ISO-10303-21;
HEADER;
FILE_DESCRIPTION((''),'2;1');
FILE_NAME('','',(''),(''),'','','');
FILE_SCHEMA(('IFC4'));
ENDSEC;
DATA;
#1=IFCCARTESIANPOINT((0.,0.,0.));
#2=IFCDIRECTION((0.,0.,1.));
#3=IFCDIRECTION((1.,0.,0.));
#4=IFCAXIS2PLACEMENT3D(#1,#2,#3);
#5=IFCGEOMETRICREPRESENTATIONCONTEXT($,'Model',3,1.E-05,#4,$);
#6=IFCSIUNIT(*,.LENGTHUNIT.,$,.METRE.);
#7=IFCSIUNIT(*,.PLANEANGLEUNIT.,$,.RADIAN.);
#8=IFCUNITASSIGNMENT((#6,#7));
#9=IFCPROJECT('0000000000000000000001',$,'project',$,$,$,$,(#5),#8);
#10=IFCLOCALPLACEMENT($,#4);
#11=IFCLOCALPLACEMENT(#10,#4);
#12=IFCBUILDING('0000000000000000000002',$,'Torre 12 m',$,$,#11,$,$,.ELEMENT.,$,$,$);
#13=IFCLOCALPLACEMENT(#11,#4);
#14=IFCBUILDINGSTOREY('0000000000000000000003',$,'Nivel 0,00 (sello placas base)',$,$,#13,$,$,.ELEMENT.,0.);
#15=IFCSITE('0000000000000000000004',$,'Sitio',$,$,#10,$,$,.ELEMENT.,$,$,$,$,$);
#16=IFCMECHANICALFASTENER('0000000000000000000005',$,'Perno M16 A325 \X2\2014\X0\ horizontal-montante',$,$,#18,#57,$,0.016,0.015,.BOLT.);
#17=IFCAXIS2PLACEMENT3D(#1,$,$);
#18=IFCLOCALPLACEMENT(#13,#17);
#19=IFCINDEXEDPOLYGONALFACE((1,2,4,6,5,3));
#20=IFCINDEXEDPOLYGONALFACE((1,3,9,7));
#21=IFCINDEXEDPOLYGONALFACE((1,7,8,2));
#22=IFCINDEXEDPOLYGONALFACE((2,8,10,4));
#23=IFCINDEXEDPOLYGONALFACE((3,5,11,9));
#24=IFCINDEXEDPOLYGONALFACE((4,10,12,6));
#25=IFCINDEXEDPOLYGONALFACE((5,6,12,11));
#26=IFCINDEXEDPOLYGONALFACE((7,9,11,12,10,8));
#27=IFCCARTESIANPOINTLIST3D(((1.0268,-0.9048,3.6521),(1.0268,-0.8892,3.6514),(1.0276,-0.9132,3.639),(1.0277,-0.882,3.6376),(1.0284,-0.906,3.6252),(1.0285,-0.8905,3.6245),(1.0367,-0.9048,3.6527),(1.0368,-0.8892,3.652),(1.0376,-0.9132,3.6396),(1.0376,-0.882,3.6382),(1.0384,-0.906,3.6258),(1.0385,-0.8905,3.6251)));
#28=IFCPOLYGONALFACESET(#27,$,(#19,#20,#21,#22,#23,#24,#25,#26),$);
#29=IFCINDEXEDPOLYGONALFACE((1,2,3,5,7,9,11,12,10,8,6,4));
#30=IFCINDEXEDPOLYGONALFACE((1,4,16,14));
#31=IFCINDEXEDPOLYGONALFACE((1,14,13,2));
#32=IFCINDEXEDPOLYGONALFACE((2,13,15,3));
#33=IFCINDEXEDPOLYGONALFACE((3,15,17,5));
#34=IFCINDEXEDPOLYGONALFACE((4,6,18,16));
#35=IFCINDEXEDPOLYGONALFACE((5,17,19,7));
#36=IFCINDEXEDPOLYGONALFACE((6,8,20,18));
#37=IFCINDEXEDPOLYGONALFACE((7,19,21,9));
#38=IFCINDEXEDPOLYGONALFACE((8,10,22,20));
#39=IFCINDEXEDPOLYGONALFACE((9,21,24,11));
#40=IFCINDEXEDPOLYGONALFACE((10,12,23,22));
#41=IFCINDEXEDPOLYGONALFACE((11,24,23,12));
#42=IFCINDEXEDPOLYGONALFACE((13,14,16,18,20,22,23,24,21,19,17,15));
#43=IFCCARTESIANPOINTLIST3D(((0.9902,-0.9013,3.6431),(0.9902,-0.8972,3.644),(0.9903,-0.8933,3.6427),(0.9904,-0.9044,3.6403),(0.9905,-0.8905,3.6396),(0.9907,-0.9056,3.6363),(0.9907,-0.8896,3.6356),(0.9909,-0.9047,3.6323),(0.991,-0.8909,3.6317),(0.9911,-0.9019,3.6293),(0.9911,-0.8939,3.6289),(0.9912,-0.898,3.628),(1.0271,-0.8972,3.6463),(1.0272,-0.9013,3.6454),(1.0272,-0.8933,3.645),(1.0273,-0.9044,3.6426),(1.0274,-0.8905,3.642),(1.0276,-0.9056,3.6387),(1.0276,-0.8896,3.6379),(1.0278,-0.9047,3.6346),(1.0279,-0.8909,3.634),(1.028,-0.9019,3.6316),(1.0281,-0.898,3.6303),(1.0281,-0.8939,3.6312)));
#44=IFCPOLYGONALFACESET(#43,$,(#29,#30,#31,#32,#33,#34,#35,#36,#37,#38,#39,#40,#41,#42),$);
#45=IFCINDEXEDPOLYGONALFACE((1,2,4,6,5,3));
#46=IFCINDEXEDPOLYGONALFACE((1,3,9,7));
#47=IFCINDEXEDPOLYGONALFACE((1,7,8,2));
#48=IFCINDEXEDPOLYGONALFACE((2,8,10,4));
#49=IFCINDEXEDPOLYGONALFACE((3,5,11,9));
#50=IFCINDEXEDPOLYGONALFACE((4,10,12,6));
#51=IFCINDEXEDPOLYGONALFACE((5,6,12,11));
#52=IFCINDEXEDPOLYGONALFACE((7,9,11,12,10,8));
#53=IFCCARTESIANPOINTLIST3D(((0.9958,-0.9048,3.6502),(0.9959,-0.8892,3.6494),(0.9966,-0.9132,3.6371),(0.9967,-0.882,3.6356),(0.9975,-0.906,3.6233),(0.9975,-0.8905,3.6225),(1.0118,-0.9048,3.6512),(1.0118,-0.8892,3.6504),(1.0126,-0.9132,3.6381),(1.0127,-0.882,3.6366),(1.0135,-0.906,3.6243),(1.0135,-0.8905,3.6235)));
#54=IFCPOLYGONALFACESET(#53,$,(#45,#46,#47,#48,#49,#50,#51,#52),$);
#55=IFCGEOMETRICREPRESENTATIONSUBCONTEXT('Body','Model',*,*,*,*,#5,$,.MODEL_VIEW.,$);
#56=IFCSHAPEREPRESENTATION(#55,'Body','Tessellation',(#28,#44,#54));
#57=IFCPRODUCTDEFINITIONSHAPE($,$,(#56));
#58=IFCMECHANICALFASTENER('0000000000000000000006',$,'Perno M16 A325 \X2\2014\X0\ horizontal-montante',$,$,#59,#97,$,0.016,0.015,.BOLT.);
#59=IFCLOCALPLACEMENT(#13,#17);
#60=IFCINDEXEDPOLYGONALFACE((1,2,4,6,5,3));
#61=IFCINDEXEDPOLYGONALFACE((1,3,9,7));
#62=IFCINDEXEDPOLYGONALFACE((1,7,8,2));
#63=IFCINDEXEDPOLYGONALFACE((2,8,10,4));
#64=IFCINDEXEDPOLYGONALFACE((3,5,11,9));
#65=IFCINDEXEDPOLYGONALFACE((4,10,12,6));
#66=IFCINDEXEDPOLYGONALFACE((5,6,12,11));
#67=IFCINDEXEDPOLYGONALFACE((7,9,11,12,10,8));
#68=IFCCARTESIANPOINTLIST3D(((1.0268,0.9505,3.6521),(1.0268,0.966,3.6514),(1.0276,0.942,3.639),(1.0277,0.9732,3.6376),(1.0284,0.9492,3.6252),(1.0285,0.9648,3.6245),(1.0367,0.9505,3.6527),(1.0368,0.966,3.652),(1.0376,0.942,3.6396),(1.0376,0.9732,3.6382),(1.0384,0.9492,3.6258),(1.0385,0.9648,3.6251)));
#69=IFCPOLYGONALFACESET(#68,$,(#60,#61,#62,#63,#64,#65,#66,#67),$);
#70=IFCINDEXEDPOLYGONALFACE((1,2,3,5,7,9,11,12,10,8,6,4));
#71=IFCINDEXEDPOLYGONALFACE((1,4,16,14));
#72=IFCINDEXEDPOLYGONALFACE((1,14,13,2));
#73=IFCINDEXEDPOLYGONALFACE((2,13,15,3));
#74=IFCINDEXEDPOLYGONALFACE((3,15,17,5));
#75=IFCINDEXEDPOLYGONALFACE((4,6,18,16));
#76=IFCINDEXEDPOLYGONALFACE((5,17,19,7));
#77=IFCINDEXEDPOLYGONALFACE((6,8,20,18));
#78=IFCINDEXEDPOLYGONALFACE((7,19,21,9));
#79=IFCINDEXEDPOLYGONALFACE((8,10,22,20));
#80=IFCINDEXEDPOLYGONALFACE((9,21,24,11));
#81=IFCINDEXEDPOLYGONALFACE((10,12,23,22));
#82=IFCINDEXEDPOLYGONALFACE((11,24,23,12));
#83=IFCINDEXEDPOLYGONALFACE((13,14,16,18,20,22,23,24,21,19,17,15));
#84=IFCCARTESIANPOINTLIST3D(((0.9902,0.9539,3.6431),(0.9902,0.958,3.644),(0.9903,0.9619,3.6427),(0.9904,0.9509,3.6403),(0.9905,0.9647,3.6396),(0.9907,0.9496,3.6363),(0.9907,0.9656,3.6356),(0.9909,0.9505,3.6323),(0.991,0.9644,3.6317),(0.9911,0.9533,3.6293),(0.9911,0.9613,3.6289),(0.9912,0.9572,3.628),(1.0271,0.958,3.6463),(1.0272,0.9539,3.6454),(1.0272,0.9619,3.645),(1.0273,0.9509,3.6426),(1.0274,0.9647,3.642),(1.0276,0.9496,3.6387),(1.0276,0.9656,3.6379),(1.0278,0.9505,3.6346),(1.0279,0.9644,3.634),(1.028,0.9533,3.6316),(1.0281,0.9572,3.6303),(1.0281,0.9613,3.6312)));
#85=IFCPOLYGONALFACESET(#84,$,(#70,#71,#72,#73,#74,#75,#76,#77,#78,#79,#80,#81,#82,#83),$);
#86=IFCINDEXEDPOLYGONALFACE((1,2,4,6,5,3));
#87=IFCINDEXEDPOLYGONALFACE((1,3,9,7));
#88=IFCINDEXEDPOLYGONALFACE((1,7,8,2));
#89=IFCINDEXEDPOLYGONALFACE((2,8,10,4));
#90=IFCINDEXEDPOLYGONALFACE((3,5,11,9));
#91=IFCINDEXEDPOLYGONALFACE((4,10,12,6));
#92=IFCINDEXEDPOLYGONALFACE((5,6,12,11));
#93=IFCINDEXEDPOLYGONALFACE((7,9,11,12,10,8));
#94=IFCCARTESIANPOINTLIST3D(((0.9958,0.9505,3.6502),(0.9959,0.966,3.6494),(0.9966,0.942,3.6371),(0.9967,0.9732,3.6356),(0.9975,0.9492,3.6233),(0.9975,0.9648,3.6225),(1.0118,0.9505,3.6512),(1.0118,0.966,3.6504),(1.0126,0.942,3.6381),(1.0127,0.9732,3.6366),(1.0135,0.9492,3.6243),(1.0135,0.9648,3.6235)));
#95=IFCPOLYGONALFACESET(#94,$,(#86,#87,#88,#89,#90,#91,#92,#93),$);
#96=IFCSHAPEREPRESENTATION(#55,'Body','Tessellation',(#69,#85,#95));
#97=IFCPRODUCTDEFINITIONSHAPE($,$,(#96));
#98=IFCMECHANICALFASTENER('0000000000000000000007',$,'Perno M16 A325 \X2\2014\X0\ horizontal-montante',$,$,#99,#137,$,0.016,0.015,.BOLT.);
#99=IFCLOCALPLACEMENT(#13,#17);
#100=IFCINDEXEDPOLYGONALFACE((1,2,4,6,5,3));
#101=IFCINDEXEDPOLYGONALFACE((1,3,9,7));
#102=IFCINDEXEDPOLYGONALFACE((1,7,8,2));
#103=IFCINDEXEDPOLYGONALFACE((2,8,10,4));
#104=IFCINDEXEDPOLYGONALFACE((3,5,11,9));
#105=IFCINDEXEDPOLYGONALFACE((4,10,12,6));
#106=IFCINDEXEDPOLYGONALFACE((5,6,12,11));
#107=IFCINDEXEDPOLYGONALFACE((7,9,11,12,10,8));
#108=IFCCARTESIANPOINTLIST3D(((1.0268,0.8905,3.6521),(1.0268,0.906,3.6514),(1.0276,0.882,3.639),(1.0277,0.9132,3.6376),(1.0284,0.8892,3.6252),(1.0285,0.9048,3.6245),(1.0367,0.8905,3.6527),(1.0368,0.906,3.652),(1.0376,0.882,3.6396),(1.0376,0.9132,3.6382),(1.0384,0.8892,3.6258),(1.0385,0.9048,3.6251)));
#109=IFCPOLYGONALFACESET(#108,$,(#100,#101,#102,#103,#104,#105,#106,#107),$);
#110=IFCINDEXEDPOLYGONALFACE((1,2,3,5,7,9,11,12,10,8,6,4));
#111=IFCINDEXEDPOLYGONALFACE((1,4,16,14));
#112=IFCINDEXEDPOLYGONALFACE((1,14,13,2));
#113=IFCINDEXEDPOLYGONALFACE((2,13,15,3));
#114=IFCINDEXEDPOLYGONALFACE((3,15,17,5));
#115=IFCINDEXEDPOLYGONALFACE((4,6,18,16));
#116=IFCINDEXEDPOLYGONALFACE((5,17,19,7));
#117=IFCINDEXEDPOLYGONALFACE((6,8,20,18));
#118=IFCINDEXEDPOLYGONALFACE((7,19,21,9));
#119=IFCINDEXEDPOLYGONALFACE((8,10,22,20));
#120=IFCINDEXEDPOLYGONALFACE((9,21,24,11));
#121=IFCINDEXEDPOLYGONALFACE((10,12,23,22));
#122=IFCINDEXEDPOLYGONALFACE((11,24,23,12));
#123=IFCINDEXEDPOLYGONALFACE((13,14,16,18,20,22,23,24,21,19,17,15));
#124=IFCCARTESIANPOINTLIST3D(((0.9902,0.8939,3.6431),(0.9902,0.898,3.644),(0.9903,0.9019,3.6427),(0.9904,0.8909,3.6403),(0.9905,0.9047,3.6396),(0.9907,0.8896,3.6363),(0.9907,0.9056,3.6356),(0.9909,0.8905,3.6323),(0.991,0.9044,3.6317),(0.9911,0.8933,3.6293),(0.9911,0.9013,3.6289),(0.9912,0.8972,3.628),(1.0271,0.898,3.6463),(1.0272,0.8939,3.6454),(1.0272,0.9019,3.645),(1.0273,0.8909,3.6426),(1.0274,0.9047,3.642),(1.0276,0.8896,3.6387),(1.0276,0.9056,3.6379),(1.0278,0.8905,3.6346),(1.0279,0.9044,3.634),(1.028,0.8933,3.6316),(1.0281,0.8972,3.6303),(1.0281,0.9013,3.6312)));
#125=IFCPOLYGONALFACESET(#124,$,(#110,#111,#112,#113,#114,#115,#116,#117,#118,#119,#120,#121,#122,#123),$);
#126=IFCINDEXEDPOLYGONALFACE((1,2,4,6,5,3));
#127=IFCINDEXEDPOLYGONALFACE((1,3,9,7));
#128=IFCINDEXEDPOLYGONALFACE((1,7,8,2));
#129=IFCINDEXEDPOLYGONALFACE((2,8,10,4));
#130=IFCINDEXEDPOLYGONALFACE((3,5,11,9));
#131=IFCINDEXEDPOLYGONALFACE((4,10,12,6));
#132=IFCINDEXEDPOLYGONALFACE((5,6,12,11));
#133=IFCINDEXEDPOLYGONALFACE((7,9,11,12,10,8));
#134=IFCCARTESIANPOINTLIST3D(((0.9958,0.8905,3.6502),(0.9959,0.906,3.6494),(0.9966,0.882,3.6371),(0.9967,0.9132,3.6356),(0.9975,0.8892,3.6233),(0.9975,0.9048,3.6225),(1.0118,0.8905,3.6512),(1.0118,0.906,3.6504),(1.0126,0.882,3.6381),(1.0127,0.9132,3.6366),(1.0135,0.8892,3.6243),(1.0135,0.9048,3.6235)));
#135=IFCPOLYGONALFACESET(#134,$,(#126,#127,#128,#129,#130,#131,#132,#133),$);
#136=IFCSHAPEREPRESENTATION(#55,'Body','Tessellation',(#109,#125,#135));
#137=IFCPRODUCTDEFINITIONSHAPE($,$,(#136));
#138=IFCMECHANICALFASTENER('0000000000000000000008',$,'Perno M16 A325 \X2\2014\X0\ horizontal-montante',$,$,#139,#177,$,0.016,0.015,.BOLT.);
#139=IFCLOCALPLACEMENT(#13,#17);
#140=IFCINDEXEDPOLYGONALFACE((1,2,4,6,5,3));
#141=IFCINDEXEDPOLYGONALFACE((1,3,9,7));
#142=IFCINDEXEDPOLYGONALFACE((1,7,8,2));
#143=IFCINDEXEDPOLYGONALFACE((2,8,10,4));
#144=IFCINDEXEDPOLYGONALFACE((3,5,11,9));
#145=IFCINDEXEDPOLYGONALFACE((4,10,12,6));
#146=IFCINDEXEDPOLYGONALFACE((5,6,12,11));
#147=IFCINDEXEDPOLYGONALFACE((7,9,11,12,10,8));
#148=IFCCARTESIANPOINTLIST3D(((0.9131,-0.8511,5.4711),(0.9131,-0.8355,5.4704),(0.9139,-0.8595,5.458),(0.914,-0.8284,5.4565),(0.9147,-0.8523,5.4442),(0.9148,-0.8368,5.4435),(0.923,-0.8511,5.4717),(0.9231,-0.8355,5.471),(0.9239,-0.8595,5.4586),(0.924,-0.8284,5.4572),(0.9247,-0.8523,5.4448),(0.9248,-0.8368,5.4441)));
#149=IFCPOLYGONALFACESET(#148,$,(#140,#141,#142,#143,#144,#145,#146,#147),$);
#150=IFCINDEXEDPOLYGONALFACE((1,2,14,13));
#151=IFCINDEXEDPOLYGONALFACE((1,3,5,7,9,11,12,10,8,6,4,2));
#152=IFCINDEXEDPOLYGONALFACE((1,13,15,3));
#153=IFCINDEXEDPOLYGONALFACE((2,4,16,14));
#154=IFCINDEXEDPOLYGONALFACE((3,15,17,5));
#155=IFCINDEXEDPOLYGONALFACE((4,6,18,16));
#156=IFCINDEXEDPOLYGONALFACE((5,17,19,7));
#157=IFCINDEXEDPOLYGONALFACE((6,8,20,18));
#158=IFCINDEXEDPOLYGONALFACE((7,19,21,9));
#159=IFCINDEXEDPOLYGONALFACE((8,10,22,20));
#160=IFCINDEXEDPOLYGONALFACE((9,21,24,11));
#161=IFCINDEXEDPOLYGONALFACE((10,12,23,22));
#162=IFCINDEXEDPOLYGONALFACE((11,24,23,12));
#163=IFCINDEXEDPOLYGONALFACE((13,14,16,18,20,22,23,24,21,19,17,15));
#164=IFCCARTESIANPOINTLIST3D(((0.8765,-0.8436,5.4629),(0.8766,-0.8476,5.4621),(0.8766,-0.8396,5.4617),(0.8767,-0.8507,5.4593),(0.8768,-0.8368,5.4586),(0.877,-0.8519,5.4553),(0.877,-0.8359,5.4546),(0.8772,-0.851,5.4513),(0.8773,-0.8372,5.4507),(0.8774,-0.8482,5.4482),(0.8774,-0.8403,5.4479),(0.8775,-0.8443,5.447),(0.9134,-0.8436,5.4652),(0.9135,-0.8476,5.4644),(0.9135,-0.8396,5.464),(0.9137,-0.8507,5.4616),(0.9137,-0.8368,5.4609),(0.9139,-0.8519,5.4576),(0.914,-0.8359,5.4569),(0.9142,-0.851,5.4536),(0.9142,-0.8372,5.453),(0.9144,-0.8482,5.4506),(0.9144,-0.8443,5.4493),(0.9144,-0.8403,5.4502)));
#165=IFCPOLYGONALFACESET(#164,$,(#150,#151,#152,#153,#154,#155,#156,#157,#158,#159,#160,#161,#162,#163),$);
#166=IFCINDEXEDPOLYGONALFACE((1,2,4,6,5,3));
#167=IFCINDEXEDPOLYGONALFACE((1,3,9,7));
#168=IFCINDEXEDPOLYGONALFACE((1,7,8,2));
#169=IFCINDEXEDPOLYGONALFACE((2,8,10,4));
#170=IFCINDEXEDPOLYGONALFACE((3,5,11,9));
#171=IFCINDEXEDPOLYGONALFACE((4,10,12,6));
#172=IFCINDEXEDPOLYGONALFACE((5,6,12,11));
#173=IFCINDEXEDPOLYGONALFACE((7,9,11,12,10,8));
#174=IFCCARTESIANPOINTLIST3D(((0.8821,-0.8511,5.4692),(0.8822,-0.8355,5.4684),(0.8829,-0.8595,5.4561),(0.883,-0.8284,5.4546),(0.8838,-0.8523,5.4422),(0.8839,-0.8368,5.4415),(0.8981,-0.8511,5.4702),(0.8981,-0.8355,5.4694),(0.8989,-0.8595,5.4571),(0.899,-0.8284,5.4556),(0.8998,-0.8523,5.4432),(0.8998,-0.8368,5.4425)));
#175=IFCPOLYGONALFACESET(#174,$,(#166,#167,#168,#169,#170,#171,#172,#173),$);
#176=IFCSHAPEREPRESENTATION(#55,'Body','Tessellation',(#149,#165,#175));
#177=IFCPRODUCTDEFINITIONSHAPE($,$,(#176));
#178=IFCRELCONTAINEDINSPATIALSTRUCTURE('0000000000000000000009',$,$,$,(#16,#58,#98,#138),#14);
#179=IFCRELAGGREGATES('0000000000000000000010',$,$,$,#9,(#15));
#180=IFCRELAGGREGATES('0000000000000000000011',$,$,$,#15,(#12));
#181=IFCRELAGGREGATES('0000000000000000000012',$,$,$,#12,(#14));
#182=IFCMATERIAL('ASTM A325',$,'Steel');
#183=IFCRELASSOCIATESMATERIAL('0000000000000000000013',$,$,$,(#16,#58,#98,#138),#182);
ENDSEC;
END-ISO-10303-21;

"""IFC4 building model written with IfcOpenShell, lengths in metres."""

from ifc_helpers import new_model, si_unit, frame, origin_with_axes, place, context, subcontext, project, spatial, polyline, outline, extrude, material, element, save


model = new_model("IFC4")

# Units and contexts
model_context = context("Model", 3, precision=1e-05, world=origin_with_axes())
body_context = subcontext(model_context, "Body", "Model", "MODEL_VIEW")
ifc_project = project(units=[si_unit("LENGTHUNIT", "METRE"), si_unit("PLANEANGLEUNIT", "RADIAN")], contexts=[model_context])

# Site, building, storey
site_placement = place(None, origin_with_axes())
site = spatial("IfcSite", under=ifc_project, at=site_placement, Name="Sitio", CompositionType="ELEMENT")
building_placement = place(site_placement, origin_with_axes())
building = spatial("IfcBuilding", under=site, at=building_placement, Name="Torre 12 m", CompositionType="ELEMENT")
storey_placement = place(building_placement, origin_with_axes())
storey = spatial("IfcBuildingStorey", under=building, at=storey_placement, Name="Nivel 0,00 (sello placas base)", CompositionType="ELEMENT", Elevation=0.0)

# Shared definitions
placement = place(storey_placement, origin_with_axes())

# Mechanical fasteners
ifc_material_1 = material(Name="ASTM A325", Category="Steel")
element("IfcMechanicalFastener", 1, at=placement, inside=storey, material=ifc_material_1, Name="Perno M16 A325 — horizontal-montante", NominalDiameter=0.016, NominalLength=0.015, PredefinedType="BOLT", context=body_context, shape_type="SweptSolid", body=[
    extrude(outline(polyline([(0.0135, 0.0078), (0.0, 0.0156), (-0.0135, 0.0078), (-0.0135, -0.0078), (0.0, -0.0156), (0.0135, -0.0078), (0.0135, 0.0078)])), frame((1.0376, -0.8976, 3.6389), z_axis=(-0.998053, 0.0, -0.062378), x_axis=(0.033672, 0.841794, -0.538748)), (0.0, 0.0, 1.0), 0.01),
    extrude(outline(polyline([(0.008, 0.0), (0.0069, 0.004), (0.004, 0.0069), (0.0, 0.008), (-0.004, 0.0069), (-0.0069, 0.004), (-0.008, 0.0), (-0.0069, -0.004), (-0.004, -0.0069), (0.0, -0.008), (0.004, -0.0069), (0.0069, -0.004), (0.008, 0.0)])), frame((1.0276, -0.8976, 3.6383), z_axis=(-0.998053, 0.0, -0.062378), x_axis=(0.033672, 0.841794, -0.538748)), (0.0, 0.0, 1.0), 0.037),
    extrude(outline(polyline([(0.0135, 0.0078), (0.0, 0.0156), (-0.0135, 0.0078), (-0.0135, -0.0078), (0.0, -0.0156), (0.0135, -0.0078), (0.0135, 0.0078)])), frame((1.0126, -0.8976, 3.6374), z_axis=(-0.998053, 0.0, -0.062378), x_axis=(0.033672, 0.841794, -0.538748)), (0.0, 0.0, 1.0), 0.016),
])
element("IfcMechanicalFastener", 2, at=placement, inside=storey, material=ifc_material_1, Name="Perno M16 A325 — horizontal-montante", NominalDiameter=0.016, NominalLength=0.015, PredefinedType="BOLT", context=body_context, shape_type="SweptSolid", body=[
    extrude(outline(polyline([(0.0135, 0.0078), (0.0, 0.0156), (-0.0135, 0.0078), (-0.0135, -0.0078), (0.0, -0.0156), (0.0135, -0.0078), (0.0135, 0.0078)])), frame((1.0376, 0.9576, 3.6389), z_axis=(-0.998053, 0.0, -0.062378), x_axis=(0.033672, 0.841794, -0.538748)), (0.0, 0.0, 1.0), 0.01),
    extrude(outline(polyline([(0.008, 0.0), (0.0069, 0.004), (0.004, 0.0069), (0.0, 0.008), (-0.004, 0.0069), (-0.0069, 0.004), (-0.008, 0.0), (-0.0069, -0.004), (-0.004, -0.0069), (0.0, -0.008), (0.004, -0.0069), (0.0069, -0.004), (0.008, 0.0)])), frame((1.0276, 0.9576, 3.6383), z_axis=(-0.998053, 0.0, -0.062378), x_axis=(0.033672, 0.841794, -0.538748)), (0.0, 0.0, 1.0), 0.037),
    extrude(outline(polyline([(0.0135, 0.0078), (0.0, 0.0156), (-0.0135, 0.0078), (-0.0135, -0.0078), (0.0, -0.0156), (0.0135, -0.0078), (0.0135, 0.0078)])), frame((1.0126, 0.9576, 3.6374), z_axis=(-0.998053, 0.0, -0.062378), x_axis=(0.033672, 0.841794, -0.538748)), (0.0, 0.0, 1.0), 0.016),
])
element("IfcMechanicalFastener", 3, at=placement, inside=storey, material=ifc_material_1, Name="Perno M16 A325 — horizontal-montante", NominalDiameter=0.016, NominalLength=0.015, PredefinedType="BOLT", context=body_context, shape_type="SweptSolid", body=[
    extrude(outline(polyline([(0.0135, 0.0078), (0.0, 0.0156), (-0.0135, 0.0078), (-0.0135, -0.0078), (0.0, -0.0156), (0.0135, -0.0078), (0.0135, 0.0078)])), frame((1.0376, 0.8976, 3.6389), z_axis=(-0.998053, 0.0, -0.062378), x_axis=(0.033672, 0.841794, -0.538748)), (0.0, 0.0, 1.0), 0.01),
    extrude(outline(polyline([(0.008, 0.0), (0.0069, 0.004), (0.004, 0.0069), (0.0, 0.008), (-0.004, 0.0069), (-0.0069, 0.004), (-0.008, 0.0), (-0.0069, -0.004), (-0.004, -0.0069), (0.0, -0.008), (0.004, -0.0069), (0.0069, -0.004), (0.008, 0.0)])), frame((1.0276, 0.8976, 3.6383), z_axis=(-0.998053, 0.0, -0.062378), x_axis=(0.033672, 0.841794, -0.538748)), (0.0, 0.0, 1.0), 0.037),
    extrude(outline(polyline([(0.0135, 0.0078), (0.0, 0.0156), (-0.0135, 0.0078), (-0.0135, -0.0078), (0.0, -0.0156), (0.0135, -0.0078), (0.0135, 0.0078)])), frame((1.0126, 0.8976, 3.6374), z_axis=(-0.998053, 0.0, -0.062378), x_axis=(0.033672, 0.841794, -0.538748)), (0.0, 0.0, 1.0), 0.016),
])
element("IfcMechanicalFastener", 4, at=placement, inside=storey, material=ifc_material_1, Name="Perno M16 A325 — horizontal-montante", NominalDiameter=0.016, NominalLength=0.015, PredefinedType="BOLT", context=body_context, shape_type="SweptSolid", body=[
    extrude(outline(polyline([(0.0135, 0.0078), (0.0, 0.0156), (-0.0135, 0.0078), (-0.0135, -0.0078), (0.0, -0.0156), (0.0135, -0.0078), (0.0135, 0.0078)])), frame((0.9239, -0.8439, 5.4579), z_axis=(-0.998053, 0.0, -0.062378), x_axis=(0.033672, 0.841794, -0.538748)), (0.0, 0.0, 1.0), 0.01),
    extrude(outline(polyline([(0.008, 0.0), (0.0069, 0.004), (0.004, 0.0069), (0.0, 0.008), (-0.004, 0.0069), (-0.0069, 0.004), (-0.008, 0.0), (-0.0069, -0.004), (-0.004, -0.0069), (0.0, -0.008), (0.004, -0.0069), (0.0069, -0.004), (0.008, 0.0)])), frame((0.9139, -0.8439, 5.4573), z_axis=(-0.998053, 0.0, -0.062378), x_axis=(0.033672, 0.841794, -0.538748)), (0.0, 0.0, 1.0), 0.037),
    extrude(outline(polyline([(0.0135, 0.0078), (0.0, 0.0156), (-0.0135, 0.0078), (-0.0135, -0.0078), (0.0, -0.0156), (0.0135, -0.0078), (0.0135, 0.0078)])), frame((0.899, -0.8439, 5.4563), z_axis=(-0.998053, 0.0, -0.062378), x_axis=(0.033672, 0.841794, -0.538748)), (0.0, 0.0, 1.0), 0.016),
])

save(model, "model.ifc")
